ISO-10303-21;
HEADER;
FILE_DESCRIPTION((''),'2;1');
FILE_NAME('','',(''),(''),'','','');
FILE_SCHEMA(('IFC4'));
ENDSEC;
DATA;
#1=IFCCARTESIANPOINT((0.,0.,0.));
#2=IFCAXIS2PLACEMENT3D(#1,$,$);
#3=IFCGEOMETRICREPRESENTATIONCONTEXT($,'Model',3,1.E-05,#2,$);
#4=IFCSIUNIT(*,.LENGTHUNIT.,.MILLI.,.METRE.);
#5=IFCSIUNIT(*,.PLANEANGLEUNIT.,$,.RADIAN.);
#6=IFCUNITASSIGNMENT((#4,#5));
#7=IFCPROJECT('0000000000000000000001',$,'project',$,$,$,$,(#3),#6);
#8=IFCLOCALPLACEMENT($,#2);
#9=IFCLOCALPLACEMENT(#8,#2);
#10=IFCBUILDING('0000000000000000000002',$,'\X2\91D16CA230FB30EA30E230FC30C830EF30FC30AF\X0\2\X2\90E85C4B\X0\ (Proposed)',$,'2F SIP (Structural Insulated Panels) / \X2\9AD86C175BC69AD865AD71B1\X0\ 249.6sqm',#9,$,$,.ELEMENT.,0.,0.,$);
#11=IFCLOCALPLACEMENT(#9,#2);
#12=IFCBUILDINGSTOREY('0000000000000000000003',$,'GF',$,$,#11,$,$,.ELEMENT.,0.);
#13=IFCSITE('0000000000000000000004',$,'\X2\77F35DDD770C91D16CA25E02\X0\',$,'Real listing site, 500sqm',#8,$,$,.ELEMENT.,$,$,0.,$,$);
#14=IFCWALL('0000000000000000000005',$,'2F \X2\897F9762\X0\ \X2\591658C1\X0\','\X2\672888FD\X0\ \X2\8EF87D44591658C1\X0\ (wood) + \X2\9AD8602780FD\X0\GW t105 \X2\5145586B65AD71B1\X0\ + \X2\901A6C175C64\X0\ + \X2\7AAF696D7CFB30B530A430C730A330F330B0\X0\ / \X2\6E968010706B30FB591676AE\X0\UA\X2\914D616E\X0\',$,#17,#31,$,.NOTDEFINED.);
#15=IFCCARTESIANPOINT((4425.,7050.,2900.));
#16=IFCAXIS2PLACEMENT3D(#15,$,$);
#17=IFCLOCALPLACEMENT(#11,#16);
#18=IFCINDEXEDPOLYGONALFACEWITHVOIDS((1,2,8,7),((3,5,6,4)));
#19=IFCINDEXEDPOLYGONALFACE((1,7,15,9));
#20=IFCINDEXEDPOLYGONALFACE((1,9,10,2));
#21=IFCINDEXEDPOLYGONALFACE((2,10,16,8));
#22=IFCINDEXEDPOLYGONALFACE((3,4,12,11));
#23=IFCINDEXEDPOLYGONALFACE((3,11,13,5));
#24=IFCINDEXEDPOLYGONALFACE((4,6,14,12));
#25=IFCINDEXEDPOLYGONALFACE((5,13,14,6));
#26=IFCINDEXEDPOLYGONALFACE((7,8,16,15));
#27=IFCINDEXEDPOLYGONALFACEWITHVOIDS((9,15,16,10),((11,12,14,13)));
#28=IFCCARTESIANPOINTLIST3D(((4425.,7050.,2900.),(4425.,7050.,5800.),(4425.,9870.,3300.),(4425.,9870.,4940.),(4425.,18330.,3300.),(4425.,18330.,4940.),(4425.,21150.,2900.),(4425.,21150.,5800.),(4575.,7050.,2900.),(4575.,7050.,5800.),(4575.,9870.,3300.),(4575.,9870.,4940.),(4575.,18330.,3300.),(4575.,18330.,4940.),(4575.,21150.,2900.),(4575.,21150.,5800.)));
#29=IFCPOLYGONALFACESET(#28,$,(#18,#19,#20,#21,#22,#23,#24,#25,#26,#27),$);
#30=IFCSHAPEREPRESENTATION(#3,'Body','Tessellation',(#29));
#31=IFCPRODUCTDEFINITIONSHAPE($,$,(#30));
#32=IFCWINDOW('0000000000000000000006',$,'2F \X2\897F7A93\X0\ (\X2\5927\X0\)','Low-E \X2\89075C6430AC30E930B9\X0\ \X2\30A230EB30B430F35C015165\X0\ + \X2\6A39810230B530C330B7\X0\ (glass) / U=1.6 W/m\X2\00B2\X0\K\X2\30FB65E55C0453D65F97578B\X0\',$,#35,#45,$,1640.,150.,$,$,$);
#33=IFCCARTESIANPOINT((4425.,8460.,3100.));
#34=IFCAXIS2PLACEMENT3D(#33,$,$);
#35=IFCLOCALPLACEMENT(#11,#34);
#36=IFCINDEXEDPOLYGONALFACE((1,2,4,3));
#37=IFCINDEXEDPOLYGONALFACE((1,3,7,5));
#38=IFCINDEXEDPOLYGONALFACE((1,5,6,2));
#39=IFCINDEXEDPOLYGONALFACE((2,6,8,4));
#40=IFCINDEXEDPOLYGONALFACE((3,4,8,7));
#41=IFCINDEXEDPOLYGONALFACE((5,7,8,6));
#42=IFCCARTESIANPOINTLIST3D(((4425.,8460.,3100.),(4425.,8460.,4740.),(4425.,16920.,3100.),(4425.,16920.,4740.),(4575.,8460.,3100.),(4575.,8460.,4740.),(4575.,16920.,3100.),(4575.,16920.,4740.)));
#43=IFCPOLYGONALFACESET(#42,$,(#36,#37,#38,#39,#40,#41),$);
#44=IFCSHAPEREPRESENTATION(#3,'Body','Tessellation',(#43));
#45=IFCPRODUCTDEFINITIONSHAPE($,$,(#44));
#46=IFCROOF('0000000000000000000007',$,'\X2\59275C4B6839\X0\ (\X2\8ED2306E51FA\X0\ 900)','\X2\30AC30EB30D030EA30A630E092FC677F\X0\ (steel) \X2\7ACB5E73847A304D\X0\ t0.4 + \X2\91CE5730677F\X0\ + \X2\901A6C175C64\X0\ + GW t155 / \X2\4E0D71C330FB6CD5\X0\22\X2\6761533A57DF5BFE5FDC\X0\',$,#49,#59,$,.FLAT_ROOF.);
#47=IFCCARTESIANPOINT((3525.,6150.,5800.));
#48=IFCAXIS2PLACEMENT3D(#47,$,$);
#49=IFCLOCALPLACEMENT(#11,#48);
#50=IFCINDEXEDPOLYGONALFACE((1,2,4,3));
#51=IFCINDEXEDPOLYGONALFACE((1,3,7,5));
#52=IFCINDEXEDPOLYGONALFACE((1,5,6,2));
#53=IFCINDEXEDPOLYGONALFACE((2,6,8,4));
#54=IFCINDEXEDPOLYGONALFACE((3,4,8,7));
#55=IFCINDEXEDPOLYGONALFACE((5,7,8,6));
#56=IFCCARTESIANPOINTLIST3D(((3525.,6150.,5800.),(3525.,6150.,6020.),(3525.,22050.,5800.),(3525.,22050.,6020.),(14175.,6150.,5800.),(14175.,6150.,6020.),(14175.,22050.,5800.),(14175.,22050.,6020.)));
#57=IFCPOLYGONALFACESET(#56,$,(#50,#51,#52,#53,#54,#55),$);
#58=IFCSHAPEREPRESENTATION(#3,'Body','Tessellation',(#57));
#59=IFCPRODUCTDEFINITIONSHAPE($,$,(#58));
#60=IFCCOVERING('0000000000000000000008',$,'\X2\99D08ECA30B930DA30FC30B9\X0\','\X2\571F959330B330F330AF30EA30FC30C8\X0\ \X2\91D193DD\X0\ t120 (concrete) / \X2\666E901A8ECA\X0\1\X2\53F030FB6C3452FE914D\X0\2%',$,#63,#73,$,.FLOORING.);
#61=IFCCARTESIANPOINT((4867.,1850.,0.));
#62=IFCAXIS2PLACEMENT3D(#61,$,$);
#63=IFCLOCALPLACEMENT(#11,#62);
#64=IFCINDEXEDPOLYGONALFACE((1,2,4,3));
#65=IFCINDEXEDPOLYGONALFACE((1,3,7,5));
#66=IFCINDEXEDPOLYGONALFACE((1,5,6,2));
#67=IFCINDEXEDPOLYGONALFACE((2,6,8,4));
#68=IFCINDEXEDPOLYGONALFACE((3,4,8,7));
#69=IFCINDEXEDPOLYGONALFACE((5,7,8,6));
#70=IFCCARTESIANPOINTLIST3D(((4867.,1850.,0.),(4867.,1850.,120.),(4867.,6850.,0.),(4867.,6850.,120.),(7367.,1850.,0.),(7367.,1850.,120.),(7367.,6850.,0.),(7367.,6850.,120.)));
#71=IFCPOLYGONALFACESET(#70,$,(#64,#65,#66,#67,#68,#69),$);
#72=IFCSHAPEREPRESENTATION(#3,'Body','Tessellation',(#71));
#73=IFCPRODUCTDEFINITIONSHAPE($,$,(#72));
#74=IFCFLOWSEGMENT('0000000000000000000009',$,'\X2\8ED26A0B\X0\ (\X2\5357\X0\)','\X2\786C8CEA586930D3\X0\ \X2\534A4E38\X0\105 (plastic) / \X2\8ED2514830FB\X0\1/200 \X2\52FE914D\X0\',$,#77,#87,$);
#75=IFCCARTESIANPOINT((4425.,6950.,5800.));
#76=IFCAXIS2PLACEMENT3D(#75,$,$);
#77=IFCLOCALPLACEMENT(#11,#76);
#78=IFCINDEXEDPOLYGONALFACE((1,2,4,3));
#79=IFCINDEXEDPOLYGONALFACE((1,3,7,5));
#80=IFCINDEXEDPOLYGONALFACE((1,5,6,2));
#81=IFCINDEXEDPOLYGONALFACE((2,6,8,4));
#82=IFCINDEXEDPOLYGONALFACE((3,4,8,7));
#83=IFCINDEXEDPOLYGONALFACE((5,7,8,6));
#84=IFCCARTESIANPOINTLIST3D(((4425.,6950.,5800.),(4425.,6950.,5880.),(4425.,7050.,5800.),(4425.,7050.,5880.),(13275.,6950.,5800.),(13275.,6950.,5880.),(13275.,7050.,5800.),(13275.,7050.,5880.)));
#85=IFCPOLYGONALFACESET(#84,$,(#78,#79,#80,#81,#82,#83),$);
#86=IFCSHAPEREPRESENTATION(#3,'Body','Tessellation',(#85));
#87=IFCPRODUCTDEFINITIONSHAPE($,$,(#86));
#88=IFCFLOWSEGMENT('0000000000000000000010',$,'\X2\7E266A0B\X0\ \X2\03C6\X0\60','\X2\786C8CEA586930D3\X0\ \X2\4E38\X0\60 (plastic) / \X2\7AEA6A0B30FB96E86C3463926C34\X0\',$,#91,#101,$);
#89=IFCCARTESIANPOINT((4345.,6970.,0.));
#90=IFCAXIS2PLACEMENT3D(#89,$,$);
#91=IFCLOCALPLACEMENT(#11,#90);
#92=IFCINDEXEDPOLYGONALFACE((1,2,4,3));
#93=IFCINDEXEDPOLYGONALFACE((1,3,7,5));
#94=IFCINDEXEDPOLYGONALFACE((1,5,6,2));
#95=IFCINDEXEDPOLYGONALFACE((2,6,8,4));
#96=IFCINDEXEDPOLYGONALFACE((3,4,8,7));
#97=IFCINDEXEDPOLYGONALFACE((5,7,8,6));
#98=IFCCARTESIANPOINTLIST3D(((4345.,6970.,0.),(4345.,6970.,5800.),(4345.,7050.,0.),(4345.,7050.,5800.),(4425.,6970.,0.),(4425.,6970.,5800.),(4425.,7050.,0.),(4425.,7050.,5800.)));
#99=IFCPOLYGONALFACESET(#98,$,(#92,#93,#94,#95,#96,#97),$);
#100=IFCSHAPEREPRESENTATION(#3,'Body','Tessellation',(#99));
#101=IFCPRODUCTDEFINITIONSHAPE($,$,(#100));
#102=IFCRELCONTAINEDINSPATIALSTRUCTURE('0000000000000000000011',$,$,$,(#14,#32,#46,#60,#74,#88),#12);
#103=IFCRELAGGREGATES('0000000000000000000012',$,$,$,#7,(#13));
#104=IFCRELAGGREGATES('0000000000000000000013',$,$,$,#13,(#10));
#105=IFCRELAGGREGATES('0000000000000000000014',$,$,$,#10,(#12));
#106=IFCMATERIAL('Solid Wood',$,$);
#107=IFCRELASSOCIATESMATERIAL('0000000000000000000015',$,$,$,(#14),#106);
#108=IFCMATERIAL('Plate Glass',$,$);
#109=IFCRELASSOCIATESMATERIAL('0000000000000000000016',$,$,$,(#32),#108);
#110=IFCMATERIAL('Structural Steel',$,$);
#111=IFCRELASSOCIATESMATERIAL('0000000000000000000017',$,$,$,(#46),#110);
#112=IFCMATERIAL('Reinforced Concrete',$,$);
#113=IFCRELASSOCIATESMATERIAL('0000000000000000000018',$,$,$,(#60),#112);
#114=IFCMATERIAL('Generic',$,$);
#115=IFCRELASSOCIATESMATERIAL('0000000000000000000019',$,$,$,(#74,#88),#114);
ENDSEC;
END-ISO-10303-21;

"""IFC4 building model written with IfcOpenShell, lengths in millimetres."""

from ifc_helpers import new_model, si_unit, frame, frame_2d, origin, place, context, project, spatial, rectangle, extrude, material, element, fill, save


model = new_model("IFC4")

# Units and contexts
model_context = context("Model", 3, precision=1e-05, world=origin())
ifc_project = project(units=[si_unit("LENGTHUNIT", "METRE", prefix="MILLI"), si_unit("PLANEANGLEUNIT", "RADIAN")], contexts=[model_context])

# Site, building, storey
site_placement = place(None, origin())
site = spatial("IfcSite", under=ifc_project, at=site_placement, Name="石川県金沢市", ObjectType="Real listing site, 500sqm", CompositionType="ELEMENT", RefElevation=0.0)
building_placement = place(site_placement, origin())
building = spatial("IfcBuilding", under=site, at=building_placement, Name="金沢・リモートワーク2部屋 (Proposed)", ObjectType="2F SIP (Structural Insulated Panels) / 高気密高断熱 249.6sqm", CompositionType="ELEMENT", ElevationOfRefHeight=0.0, ElevationOfTerrain=0.0)
storey_placement = place(building_placement, origin())
storey = spatial("IfcBuildingStorey", under=building, at=storey_placement, Name="GF", CompositionType="ELEMENT", Elevation=0.0)

# Shared definitions
ifc_material_1 = material(Name="Solid Wood")

# Shared definitions
ifc_material_2 = material(Name="Reinforced Concrete")

# Shared definitions
ifc_material_3 = material(Name="Plate Glass")

# Wall, opening, window
wall_1_placement = place(storey_placement, frame((4425.0, 7050.0, 2900.0)))
wall_1 = element("IfcWall", 1, at=wall_1_placement, inside=storey, material=ifc_material_1, Name="2F 西面 外壁", Description="木製 軸組外壁 (wood) + 高性能GW t105 充填断熱 + 通気層 + 窯業系サイディング / 準耐火・外皮UA配慮", PredefinedType="NOTDEFINED", context=model_context, shape_type="SweptSolid", body=[
    extrude(rectangle(XDim=150.0, YDim=14100.0, at=frame_2d((75.0, 7050.0))), frame((4425.0, 7050.0, 2900.0)), (0.0, 0.0, 1.0), 2900.0),
])
opening_1_placement = place(storey_placement, frame((4425.0, 8460.0, 3100.0)))
opening_1 = element("IfcOpeningElement", 2, at=opening_1_placement, cuts=wall_1, PredefinedType="NOTDEFINED", context=model_context, shape_type="SweptSolid", body=[
    extrude(rectangle(XDim=150.0, YDim=8460.0, at=frame_2d((75.0, 4230.0))), frame((4425.0, 8460.0, 3100.0)), (0.0, 0.0, 1.0), 1640.0),
])
window_1_placement = place(storey_placement, frame((4425.0, 8460.0, 3100.0)))
window_1 = element("IfcWindow", 3, at=window_1_placement, inside=storey, material=ifc_material_3, Name="2F 西窓 (大)", Description="Low-E 複層ガラス アルゴン封入 + 樹脂サッシ (glass) / U=1.6 W/m²K・日射取得型", OverallHeight=1640.0, OverallWidth=150.0, context=model_context, shape_type="SweptSolid", body=[
    extrude(rectangle(XDim=150.0, YDim=8460.0, at=frame_2d((75.0, 4230.0))), frame((4425.0, 8460.0, 3100.0)), (0.0, 0.0, 1.0), 1640.0),
])
fill(opening_1, window_1)

# Roof
ifc_material_4 = material(Name="Structural Steel")
roof_placement = place(storey_placement, frame((3525.0, 6150.0, 5800.0)))
element("IfcRoof", 4, at=roof_placement, inside=storey, material=ifc_material_4, Name="大屋根 (軒の出 900)", Description="ガルバリウム鋼板 (steel) 立平葺き t0.4 + 野地板 + 通気層 + GW t155 / 不燃・法22条区域対応", PredefinedType="FLAT_ROOF", context=model_context, shape_type="SweptSolid", body=[
    extrude(rectangle(XDim=10650.0, YDim=15900.0, at=frame_2d((5325.0, 7950.0))), frame((3525.0, 6150.0, 5800.0)), (0.0, 0.0, 1.0), 220.0),
])

# Covering
covering_placement = place(storey_placement, frame((4867.0, 1850.0, 0.0)))
element("IfcCovering", 5, at=covering_placement, inside=storey, material=ifc_material_2, Name="駐車スペース", Description="土間コンクリート 金鏝 t120 (concrete) / 普通車1台・水勾配2%", PredefinedType="FLOORING", context=model_context, shape_type="SweptSolid", body=[
    extrude(rectangle(XDim=2500.0, YDim=5000.0, at=frame_2d((1250.0, 2500.0))), frame((4867.0, 1850.0, 0.0)), (0.0, 0.0, 1.0), 120.0),
])

# Flow segments
ifc_material_5 = material(Name="Generic")
flow_segment_1_placement = place(storey_placement, frame((4425.0, 6950.0, 5800.0)))
element("IfcFlowSegment", 6, at=flow_segment_1_placement, inside=storey, material=ifc_material_5, Name="軒樋 (南)", Description="硬質塩ビ 半丸105 (plastic) / 軒先・1/200 勾配", context=model_context, shape_type="SweptSolid", body=[
    extrude(rectangle(XDim=8850.0, YDim=100.0, at=frame_2d((4425.0, 50.0))), frame((4425.0, 6950.0, 5800.0)), (0.0, 0.0, 1.0), 80.0),
])
flow_segment_2_placement = place(storey_placement, frame((4345.0, 6970.0, 0.0)))
element("IfcFlowSegment", 7, at=flow_segment_2_placement, inside=storey, material=ifc_material_5, Name="縦樋 φ60", Description="硬質塩ビ 丸60 (plastic) / 竪樋・雨水排水", context=model_context, shape_type="SweptSolid", body=[
    extrude(rectangle(XDim=80.0, YDim=80.0, at=frame_2d((40.0, 40.0))), frame((4345.0, 6970.0, 0.0)), (0.0, 0.0, 1.0), 5800.0),
])

save(model, "model.ifc")
